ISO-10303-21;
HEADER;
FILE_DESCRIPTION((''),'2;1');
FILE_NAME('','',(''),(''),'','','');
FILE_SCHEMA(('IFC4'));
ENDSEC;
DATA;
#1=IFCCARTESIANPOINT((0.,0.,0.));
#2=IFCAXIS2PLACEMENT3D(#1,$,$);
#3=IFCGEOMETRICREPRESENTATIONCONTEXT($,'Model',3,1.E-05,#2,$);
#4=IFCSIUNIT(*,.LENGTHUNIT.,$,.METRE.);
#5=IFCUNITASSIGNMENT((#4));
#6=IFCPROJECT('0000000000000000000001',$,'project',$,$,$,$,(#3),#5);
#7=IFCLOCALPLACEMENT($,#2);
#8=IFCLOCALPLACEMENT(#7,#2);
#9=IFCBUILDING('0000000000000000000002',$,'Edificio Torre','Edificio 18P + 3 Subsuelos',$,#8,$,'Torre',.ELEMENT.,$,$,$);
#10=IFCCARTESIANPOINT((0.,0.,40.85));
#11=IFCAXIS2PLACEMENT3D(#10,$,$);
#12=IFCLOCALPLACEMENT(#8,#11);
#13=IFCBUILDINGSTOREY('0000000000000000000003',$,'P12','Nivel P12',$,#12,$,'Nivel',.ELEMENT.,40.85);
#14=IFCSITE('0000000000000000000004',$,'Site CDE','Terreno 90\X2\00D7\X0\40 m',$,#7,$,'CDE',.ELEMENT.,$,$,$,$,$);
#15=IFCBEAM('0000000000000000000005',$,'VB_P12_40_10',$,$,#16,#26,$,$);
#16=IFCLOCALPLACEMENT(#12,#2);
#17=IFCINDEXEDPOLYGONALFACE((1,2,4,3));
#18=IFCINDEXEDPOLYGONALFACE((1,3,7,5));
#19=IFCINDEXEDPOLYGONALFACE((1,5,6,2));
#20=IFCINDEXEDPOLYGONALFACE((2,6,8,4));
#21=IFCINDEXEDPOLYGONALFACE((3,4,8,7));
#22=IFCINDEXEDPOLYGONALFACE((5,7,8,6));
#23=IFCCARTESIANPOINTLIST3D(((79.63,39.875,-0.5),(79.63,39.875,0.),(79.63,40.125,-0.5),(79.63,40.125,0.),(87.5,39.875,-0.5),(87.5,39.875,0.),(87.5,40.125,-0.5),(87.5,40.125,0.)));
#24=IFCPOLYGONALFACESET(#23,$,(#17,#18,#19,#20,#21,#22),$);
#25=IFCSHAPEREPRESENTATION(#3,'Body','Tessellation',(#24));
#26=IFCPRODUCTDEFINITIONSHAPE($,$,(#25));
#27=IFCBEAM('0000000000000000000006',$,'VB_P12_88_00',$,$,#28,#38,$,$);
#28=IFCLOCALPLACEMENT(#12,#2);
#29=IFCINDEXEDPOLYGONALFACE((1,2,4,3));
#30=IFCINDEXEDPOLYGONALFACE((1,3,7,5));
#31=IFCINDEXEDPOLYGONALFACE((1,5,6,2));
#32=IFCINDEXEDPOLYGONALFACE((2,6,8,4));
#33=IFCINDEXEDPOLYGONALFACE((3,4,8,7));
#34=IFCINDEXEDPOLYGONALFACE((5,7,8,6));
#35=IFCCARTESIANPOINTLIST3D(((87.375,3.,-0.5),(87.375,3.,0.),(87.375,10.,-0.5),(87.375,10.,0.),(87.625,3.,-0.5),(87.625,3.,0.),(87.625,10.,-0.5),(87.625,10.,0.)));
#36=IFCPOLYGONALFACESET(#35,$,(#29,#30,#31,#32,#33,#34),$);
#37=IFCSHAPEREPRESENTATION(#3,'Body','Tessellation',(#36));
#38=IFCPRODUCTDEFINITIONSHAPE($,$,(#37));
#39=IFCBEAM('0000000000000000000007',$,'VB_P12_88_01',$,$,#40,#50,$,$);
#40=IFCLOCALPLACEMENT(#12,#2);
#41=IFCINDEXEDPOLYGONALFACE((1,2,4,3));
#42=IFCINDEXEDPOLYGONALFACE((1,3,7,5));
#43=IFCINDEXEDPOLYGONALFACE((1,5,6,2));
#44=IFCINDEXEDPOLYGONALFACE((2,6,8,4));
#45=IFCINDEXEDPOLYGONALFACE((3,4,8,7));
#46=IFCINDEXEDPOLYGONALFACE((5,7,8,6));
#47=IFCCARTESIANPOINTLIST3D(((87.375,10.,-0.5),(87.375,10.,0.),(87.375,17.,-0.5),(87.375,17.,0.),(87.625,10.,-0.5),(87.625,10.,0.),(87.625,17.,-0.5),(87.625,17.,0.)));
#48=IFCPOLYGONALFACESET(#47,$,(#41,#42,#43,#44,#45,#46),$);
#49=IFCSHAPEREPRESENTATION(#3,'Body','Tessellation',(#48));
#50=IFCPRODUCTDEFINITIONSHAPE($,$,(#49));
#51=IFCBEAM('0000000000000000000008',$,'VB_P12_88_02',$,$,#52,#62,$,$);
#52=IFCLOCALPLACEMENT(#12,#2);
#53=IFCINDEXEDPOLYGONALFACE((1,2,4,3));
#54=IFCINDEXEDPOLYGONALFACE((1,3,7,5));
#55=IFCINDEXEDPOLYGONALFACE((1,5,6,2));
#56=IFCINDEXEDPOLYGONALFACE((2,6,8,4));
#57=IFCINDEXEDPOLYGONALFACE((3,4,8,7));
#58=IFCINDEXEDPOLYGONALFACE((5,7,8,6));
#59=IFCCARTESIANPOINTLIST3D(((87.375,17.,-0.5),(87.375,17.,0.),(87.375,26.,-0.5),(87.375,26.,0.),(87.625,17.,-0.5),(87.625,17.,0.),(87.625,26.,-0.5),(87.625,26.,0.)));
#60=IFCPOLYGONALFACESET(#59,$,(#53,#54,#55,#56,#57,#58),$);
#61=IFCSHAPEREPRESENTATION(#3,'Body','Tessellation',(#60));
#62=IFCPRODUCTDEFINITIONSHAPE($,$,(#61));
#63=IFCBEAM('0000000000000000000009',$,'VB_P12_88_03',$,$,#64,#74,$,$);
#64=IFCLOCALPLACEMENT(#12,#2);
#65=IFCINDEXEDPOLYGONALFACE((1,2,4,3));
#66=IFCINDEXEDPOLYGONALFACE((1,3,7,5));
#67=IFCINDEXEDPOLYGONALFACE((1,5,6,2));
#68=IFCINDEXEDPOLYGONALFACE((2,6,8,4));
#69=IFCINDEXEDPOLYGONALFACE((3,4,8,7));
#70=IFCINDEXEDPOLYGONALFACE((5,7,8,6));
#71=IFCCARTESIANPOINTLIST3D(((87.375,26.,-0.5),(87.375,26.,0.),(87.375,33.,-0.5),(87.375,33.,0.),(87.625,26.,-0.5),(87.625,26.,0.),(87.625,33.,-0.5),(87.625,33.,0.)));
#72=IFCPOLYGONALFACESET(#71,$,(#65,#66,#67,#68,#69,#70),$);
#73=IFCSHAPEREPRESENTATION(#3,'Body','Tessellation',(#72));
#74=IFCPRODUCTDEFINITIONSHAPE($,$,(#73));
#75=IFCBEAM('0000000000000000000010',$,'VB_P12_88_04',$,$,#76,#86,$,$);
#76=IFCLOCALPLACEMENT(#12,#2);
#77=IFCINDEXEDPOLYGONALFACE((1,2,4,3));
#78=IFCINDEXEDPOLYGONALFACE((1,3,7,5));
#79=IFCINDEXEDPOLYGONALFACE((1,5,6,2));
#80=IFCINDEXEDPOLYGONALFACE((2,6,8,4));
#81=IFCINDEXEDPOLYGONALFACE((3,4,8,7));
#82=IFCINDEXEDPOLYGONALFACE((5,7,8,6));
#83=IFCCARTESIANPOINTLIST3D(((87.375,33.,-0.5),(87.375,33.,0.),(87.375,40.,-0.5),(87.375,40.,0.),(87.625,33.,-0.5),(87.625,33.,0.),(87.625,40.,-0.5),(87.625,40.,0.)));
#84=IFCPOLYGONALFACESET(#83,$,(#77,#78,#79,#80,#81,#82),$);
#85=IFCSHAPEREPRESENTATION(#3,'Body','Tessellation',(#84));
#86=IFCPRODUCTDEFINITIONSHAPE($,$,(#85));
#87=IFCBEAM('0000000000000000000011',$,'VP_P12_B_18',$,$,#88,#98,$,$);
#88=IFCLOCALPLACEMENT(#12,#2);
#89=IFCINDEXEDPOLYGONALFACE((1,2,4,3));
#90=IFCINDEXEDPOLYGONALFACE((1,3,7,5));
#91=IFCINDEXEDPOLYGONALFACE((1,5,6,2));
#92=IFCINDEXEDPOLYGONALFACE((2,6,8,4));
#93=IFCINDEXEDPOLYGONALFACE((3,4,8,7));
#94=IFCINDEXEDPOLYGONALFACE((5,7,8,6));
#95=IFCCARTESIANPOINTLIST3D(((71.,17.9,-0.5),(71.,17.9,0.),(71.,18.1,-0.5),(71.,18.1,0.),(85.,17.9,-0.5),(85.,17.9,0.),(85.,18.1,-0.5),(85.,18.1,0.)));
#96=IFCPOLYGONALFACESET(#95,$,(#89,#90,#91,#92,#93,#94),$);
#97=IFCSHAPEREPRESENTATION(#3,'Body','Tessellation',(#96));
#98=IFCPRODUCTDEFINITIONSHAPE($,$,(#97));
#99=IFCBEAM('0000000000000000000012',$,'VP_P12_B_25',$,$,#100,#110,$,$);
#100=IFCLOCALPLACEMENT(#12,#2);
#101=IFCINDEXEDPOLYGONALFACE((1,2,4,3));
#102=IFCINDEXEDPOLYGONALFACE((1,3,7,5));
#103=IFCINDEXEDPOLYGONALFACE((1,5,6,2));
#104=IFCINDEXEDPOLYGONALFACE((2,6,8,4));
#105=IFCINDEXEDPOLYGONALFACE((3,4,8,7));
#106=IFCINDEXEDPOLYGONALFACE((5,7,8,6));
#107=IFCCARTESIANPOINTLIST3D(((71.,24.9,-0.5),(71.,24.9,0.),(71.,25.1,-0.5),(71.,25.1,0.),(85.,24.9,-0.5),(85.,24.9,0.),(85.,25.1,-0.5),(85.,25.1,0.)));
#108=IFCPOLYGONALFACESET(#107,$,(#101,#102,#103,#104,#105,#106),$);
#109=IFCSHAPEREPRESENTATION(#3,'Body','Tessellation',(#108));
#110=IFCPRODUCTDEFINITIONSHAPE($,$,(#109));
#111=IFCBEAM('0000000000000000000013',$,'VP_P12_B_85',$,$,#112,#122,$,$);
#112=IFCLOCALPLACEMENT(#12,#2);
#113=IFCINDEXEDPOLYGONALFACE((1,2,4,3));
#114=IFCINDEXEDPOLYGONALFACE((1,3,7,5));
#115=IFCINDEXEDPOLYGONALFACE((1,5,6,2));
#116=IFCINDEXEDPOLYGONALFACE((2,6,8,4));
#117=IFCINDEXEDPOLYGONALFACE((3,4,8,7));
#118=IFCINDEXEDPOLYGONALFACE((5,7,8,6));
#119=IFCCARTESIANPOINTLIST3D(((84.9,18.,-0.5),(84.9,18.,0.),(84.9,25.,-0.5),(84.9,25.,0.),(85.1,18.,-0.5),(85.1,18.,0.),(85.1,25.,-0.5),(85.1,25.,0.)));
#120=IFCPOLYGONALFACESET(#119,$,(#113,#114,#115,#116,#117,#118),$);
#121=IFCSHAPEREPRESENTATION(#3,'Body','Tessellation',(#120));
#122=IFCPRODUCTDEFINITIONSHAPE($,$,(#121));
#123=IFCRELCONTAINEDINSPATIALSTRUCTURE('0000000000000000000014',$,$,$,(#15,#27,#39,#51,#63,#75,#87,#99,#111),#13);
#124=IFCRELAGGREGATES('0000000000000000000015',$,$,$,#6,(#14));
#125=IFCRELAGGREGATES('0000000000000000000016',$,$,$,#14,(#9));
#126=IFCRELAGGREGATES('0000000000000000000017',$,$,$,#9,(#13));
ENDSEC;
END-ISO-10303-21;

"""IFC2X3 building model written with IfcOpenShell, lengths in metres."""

from ifc_helpers import new_model, si_unit, frame, origin, origin_2d, place, context, project, spatial, rectangle, extrude, element, save


model = new_model("IFC2X3")

# Units and contexts
model_context = context("Model", 3, precision=1e-05, world=origin())
ifc_project = project(units=[si_unit("LENGTHUNIT", "METRE")], contexts=[model_context])

# Site, building, storey
site_placement = place(None, origin())
site = spatial("IfcSite", under=ifc_project, at=site_placement, Name="Site CDE", Description="Terreno 90×40 m", LongName="CDE", CompositionType="ELEMENT")
building_placement = place(site_placement, origin())
building = spatial("IfcBuilding", under=site, at=building_placement, Name="Edificio Torre", Description="Edificio 18P + 3 Subsuelos", LongName="Torre", CompositionType="ELEMENT")
storey_placement = place(building_placement, frame((0.0, 0.0, 40.85)))
storey = spatial("IfcBuildingStorey", under=building, at=storey_placement, Name="P12", Description="Nivel P12", LongName="Nivel", CompositionType="ELEMENT", Elevation=40.85)

# Beams
beam_1_placement = place(storey_placement, frame((83.565, 40.0, -0.5)))
element("IfcBeam", 1, at=beam_1_placement, inside=storey, Name="VB_P12_40_10", context=model_context, shape_type="SweptSolid", body=[
    extrude(rectangle(XDim=7.87, YDim=0.25, at=origin_2d()), origin(), (0.0, 0.0, 1.0), 0.5),
])
for number, where, name in (
    (2, (87.5, 6.5, -0.5), "VB_P12_88_00"),
    (3, (87.5, 13.5, -0.5), "VB_P12_88_01"),
):
    element("IfcBeam", number, at=place(storey_placement, frame(where)), inside=storey, Name=name, context=model_context, shape_type="SweptSolid", body=[
        extrude(rectangle(XDim=0.25, YDim=7.0, at=origin_2d()), origin(), (0.0, 0.0, 1.0), 0.5),
    ])
beam_2_placement = place(storey_placement, frame((87.5, 21.5, -0.5)))
element("IfcBeam", 4, at=beam_2_placement, inside=storey, Name="VB_P12_88_02", context=model_context, shape_type="SweptSolid", body=[
    extrude(rectangle(XDim=0.25, YDim=9.0, at=origin_2d()), origin(), (0.0, 0.0, 1.0), 0.5),
])
for number, where, name in (
    (5, (87.5, 29.5, -0.5), "VB_P12_88_03"),
    (6, (87.5, 36.5, -0.5), "VB_P12_88_04"),
):
    element("IfcBeam", number, at=place(storey_placement, frame(where)), inside=storey, Name=name, context=model_context, shape_type="SweptSolid", body=[
        extrude(rectangle(XDim=0.25, YDim=7.0, at=origin_2d()), origin(), (0.0, 0.0, 1.0), 0.5),
    ])
for number, where, name in (
    (7, (78.0, 18.0, -0.5), "VP_P12_B_18"),
    (8, (78.0, 25.0, -0.5), "VP_P12_B_25"),
):
    element("IfcBeam", number, at=place(storey_placement, frame(where)), inside=storey, Name=name, context=model_context, shape_type="SweptSolid", body=[
        extrude(rectangle(XDim=14.0, YDim=0.2, at=origin_2d()), origin(), (0.0, 0.0, 1.0), 0.5),
    ])
beam_3_placement = place(storey_placement, frame((85.0, 21.5, -0.5)))
element("IfcBeam", 9, at=beam_3_placement, inside=storey, Name="VP_P12_B_85", context=model_context, shape_type="SweptSolid", body=[
    extrude(rectangle(XDim=0.2, YDim=7.0, at=origin_2d()), origin(), (0.0, 0.0, 1.0), 0.5),
])

save(model, "model.ifc")
